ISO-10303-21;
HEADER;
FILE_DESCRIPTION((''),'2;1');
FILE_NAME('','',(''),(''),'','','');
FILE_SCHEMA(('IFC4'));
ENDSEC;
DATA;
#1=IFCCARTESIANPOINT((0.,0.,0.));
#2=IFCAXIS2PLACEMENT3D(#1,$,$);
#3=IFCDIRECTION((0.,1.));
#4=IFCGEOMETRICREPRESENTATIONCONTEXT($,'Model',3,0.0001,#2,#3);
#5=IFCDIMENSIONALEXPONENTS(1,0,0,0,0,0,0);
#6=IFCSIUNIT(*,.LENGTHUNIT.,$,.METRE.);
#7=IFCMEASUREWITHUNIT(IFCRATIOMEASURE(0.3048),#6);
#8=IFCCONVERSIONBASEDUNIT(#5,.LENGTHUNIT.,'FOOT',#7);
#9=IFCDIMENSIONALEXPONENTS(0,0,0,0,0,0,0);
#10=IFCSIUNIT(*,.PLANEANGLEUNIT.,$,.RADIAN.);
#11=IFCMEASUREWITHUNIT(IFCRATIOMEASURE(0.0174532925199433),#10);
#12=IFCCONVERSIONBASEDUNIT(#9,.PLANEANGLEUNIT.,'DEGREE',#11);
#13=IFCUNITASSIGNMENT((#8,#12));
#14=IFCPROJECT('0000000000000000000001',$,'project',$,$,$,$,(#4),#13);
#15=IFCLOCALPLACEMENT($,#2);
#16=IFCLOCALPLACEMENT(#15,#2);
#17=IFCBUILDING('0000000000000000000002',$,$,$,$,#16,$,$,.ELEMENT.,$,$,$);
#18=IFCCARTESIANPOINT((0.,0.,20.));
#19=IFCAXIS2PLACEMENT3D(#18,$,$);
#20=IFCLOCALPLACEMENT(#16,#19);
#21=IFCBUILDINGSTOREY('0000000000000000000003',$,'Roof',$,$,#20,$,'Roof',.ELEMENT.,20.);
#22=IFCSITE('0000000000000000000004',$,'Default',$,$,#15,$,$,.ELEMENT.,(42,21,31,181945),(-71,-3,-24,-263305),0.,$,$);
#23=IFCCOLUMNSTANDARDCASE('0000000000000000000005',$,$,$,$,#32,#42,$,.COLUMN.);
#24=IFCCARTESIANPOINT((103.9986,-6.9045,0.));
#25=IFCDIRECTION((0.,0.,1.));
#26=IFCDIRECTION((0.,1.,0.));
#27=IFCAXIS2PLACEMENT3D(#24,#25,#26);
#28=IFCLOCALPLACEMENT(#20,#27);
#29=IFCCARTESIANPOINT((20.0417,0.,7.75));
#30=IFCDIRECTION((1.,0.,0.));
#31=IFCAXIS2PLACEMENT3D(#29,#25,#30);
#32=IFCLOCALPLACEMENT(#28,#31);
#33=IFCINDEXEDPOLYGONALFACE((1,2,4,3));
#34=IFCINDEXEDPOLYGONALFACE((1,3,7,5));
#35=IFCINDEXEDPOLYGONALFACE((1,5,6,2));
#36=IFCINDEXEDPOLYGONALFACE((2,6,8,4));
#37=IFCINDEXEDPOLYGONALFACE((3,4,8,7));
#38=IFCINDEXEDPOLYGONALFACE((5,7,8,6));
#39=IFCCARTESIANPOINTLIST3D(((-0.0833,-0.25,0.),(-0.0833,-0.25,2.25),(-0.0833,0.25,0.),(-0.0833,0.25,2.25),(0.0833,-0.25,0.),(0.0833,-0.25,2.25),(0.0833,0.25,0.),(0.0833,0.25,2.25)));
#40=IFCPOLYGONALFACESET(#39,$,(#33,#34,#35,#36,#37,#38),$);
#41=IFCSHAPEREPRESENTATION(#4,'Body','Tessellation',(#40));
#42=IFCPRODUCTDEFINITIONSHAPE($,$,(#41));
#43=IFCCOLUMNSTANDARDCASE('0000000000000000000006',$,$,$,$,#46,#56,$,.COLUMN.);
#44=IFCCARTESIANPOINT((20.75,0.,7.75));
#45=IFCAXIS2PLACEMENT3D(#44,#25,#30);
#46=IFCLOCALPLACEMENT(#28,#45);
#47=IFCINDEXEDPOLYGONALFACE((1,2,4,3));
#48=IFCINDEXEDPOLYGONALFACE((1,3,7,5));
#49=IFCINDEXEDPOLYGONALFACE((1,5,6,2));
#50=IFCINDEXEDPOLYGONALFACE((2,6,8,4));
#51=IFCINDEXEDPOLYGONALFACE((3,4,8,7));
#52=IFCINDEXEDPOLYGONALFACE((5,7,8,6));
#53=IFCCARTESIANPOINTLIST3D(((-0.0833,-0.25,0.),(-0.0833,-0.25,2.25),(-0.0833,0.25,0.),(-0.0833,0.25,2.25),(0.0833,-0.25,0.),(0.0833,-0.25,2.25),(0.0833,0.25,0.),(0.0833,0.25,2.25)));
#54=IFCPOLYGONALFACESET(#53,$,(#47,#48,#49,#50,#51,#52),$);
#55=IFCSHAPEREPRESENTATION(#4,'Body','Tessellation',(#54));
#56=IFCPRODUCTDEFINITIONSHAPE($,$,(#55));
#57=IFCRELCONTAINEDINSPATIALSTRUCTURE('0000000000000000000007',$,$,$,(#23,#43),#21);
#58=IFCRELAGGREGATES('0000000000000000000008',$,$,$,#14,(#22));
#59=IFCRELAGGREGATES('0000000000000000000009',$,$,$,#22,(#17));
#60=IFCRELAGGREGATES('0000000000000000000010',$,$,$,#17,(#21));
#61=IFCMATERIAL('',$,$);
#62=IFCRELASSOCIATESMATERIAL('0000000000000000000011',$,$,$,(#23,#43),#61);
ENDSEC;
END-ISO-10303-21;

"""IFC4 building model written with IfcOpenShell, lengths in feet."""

from ifc_helpers import new_model, entity, si_unit, converted_unit, direction, frame, origin, place, context, project, spatial, rectangle, extrude, material, element, save


model = new_model("IFC4")

# Units and contexts
model_context = context("Model", 3, precision=0.0001, world=origin(), true_north=direction((0.0, 1.0)))
ifc_project = project(units=[converted_unit("LENGTHUNIT", "FOOT", entity("IfcRatioMeasure", 0.3048), si_unit("LENGTHUNIT", "METRE"), dimensions=[1, 0, 0, 0, 0, 0, 0]), converted_unit("PLANEANGLEUNIT", "DEGREE", entity("IfcRatioMeasure", 0.0174532925199433), si_unit("PLANEANGLEUNIT", "RADIAN"), dimensions=[0, 0, 0, 0, 0, 0, 0])], contexts=[model_context])

# Site, building, storey
site_placement = place(None, origin())
site = spatial("IfcSite", under=ifc_project, at=site_placement, Name="Default", CompositionType="ELEMENT", RefLatitude=(42, 21, 31, 181945), RefLongitude=(-71, -3, -24, -263305), RefElevation=0.0)
building_placement = place(site_placement, origin())
building = spatial("IfcBuilding", under=site, at=building_placement, CompositionType="ELEMENT")
storey_placement = place(building_placement, frame((0.0, 0.0, 20.0)))
storey = spatial("IfcBuildingStorey", under=building, at=storey_placement, Name="Roof", LongName="Roof", CompositionType="ELEMENT", Elevation=20.0)

# Columns
placement = place(storey_placement, frame((103.9986, -6.9045, 0.0), z_axis=(0.0, 0.0, 1.0), x_axis=(0.0, 1.0, 0.0)))
ifc_material_1 = material(Name="")
for number, where, z_axis, x_axis in (
    (1, (20.0417, 0.0, 7.75), (0.0, 0.0, 1.0), (1.0, 0.0, 0.0)),
    (2, (20.75, 0.0, 7.75), (0.0, 0.0, 1.0), (1.0, 0.0, 0.0)),
):
    element("IfcColumnStandardCase", number, at=place(placement, frame(where, z_axis=z_axis, x_axis=x_axis)), inside=storey, material=ifc_material_1, PredefinedType="COLUMN", context=model_context, shape_type="SweptSolid", body=[
        extrude(rectangle(XDim=0.1667, YDim=0.5), origin(), (0.0, 0.0, 1.0), 2.25),
    ])

save(model, "model.ifc")
